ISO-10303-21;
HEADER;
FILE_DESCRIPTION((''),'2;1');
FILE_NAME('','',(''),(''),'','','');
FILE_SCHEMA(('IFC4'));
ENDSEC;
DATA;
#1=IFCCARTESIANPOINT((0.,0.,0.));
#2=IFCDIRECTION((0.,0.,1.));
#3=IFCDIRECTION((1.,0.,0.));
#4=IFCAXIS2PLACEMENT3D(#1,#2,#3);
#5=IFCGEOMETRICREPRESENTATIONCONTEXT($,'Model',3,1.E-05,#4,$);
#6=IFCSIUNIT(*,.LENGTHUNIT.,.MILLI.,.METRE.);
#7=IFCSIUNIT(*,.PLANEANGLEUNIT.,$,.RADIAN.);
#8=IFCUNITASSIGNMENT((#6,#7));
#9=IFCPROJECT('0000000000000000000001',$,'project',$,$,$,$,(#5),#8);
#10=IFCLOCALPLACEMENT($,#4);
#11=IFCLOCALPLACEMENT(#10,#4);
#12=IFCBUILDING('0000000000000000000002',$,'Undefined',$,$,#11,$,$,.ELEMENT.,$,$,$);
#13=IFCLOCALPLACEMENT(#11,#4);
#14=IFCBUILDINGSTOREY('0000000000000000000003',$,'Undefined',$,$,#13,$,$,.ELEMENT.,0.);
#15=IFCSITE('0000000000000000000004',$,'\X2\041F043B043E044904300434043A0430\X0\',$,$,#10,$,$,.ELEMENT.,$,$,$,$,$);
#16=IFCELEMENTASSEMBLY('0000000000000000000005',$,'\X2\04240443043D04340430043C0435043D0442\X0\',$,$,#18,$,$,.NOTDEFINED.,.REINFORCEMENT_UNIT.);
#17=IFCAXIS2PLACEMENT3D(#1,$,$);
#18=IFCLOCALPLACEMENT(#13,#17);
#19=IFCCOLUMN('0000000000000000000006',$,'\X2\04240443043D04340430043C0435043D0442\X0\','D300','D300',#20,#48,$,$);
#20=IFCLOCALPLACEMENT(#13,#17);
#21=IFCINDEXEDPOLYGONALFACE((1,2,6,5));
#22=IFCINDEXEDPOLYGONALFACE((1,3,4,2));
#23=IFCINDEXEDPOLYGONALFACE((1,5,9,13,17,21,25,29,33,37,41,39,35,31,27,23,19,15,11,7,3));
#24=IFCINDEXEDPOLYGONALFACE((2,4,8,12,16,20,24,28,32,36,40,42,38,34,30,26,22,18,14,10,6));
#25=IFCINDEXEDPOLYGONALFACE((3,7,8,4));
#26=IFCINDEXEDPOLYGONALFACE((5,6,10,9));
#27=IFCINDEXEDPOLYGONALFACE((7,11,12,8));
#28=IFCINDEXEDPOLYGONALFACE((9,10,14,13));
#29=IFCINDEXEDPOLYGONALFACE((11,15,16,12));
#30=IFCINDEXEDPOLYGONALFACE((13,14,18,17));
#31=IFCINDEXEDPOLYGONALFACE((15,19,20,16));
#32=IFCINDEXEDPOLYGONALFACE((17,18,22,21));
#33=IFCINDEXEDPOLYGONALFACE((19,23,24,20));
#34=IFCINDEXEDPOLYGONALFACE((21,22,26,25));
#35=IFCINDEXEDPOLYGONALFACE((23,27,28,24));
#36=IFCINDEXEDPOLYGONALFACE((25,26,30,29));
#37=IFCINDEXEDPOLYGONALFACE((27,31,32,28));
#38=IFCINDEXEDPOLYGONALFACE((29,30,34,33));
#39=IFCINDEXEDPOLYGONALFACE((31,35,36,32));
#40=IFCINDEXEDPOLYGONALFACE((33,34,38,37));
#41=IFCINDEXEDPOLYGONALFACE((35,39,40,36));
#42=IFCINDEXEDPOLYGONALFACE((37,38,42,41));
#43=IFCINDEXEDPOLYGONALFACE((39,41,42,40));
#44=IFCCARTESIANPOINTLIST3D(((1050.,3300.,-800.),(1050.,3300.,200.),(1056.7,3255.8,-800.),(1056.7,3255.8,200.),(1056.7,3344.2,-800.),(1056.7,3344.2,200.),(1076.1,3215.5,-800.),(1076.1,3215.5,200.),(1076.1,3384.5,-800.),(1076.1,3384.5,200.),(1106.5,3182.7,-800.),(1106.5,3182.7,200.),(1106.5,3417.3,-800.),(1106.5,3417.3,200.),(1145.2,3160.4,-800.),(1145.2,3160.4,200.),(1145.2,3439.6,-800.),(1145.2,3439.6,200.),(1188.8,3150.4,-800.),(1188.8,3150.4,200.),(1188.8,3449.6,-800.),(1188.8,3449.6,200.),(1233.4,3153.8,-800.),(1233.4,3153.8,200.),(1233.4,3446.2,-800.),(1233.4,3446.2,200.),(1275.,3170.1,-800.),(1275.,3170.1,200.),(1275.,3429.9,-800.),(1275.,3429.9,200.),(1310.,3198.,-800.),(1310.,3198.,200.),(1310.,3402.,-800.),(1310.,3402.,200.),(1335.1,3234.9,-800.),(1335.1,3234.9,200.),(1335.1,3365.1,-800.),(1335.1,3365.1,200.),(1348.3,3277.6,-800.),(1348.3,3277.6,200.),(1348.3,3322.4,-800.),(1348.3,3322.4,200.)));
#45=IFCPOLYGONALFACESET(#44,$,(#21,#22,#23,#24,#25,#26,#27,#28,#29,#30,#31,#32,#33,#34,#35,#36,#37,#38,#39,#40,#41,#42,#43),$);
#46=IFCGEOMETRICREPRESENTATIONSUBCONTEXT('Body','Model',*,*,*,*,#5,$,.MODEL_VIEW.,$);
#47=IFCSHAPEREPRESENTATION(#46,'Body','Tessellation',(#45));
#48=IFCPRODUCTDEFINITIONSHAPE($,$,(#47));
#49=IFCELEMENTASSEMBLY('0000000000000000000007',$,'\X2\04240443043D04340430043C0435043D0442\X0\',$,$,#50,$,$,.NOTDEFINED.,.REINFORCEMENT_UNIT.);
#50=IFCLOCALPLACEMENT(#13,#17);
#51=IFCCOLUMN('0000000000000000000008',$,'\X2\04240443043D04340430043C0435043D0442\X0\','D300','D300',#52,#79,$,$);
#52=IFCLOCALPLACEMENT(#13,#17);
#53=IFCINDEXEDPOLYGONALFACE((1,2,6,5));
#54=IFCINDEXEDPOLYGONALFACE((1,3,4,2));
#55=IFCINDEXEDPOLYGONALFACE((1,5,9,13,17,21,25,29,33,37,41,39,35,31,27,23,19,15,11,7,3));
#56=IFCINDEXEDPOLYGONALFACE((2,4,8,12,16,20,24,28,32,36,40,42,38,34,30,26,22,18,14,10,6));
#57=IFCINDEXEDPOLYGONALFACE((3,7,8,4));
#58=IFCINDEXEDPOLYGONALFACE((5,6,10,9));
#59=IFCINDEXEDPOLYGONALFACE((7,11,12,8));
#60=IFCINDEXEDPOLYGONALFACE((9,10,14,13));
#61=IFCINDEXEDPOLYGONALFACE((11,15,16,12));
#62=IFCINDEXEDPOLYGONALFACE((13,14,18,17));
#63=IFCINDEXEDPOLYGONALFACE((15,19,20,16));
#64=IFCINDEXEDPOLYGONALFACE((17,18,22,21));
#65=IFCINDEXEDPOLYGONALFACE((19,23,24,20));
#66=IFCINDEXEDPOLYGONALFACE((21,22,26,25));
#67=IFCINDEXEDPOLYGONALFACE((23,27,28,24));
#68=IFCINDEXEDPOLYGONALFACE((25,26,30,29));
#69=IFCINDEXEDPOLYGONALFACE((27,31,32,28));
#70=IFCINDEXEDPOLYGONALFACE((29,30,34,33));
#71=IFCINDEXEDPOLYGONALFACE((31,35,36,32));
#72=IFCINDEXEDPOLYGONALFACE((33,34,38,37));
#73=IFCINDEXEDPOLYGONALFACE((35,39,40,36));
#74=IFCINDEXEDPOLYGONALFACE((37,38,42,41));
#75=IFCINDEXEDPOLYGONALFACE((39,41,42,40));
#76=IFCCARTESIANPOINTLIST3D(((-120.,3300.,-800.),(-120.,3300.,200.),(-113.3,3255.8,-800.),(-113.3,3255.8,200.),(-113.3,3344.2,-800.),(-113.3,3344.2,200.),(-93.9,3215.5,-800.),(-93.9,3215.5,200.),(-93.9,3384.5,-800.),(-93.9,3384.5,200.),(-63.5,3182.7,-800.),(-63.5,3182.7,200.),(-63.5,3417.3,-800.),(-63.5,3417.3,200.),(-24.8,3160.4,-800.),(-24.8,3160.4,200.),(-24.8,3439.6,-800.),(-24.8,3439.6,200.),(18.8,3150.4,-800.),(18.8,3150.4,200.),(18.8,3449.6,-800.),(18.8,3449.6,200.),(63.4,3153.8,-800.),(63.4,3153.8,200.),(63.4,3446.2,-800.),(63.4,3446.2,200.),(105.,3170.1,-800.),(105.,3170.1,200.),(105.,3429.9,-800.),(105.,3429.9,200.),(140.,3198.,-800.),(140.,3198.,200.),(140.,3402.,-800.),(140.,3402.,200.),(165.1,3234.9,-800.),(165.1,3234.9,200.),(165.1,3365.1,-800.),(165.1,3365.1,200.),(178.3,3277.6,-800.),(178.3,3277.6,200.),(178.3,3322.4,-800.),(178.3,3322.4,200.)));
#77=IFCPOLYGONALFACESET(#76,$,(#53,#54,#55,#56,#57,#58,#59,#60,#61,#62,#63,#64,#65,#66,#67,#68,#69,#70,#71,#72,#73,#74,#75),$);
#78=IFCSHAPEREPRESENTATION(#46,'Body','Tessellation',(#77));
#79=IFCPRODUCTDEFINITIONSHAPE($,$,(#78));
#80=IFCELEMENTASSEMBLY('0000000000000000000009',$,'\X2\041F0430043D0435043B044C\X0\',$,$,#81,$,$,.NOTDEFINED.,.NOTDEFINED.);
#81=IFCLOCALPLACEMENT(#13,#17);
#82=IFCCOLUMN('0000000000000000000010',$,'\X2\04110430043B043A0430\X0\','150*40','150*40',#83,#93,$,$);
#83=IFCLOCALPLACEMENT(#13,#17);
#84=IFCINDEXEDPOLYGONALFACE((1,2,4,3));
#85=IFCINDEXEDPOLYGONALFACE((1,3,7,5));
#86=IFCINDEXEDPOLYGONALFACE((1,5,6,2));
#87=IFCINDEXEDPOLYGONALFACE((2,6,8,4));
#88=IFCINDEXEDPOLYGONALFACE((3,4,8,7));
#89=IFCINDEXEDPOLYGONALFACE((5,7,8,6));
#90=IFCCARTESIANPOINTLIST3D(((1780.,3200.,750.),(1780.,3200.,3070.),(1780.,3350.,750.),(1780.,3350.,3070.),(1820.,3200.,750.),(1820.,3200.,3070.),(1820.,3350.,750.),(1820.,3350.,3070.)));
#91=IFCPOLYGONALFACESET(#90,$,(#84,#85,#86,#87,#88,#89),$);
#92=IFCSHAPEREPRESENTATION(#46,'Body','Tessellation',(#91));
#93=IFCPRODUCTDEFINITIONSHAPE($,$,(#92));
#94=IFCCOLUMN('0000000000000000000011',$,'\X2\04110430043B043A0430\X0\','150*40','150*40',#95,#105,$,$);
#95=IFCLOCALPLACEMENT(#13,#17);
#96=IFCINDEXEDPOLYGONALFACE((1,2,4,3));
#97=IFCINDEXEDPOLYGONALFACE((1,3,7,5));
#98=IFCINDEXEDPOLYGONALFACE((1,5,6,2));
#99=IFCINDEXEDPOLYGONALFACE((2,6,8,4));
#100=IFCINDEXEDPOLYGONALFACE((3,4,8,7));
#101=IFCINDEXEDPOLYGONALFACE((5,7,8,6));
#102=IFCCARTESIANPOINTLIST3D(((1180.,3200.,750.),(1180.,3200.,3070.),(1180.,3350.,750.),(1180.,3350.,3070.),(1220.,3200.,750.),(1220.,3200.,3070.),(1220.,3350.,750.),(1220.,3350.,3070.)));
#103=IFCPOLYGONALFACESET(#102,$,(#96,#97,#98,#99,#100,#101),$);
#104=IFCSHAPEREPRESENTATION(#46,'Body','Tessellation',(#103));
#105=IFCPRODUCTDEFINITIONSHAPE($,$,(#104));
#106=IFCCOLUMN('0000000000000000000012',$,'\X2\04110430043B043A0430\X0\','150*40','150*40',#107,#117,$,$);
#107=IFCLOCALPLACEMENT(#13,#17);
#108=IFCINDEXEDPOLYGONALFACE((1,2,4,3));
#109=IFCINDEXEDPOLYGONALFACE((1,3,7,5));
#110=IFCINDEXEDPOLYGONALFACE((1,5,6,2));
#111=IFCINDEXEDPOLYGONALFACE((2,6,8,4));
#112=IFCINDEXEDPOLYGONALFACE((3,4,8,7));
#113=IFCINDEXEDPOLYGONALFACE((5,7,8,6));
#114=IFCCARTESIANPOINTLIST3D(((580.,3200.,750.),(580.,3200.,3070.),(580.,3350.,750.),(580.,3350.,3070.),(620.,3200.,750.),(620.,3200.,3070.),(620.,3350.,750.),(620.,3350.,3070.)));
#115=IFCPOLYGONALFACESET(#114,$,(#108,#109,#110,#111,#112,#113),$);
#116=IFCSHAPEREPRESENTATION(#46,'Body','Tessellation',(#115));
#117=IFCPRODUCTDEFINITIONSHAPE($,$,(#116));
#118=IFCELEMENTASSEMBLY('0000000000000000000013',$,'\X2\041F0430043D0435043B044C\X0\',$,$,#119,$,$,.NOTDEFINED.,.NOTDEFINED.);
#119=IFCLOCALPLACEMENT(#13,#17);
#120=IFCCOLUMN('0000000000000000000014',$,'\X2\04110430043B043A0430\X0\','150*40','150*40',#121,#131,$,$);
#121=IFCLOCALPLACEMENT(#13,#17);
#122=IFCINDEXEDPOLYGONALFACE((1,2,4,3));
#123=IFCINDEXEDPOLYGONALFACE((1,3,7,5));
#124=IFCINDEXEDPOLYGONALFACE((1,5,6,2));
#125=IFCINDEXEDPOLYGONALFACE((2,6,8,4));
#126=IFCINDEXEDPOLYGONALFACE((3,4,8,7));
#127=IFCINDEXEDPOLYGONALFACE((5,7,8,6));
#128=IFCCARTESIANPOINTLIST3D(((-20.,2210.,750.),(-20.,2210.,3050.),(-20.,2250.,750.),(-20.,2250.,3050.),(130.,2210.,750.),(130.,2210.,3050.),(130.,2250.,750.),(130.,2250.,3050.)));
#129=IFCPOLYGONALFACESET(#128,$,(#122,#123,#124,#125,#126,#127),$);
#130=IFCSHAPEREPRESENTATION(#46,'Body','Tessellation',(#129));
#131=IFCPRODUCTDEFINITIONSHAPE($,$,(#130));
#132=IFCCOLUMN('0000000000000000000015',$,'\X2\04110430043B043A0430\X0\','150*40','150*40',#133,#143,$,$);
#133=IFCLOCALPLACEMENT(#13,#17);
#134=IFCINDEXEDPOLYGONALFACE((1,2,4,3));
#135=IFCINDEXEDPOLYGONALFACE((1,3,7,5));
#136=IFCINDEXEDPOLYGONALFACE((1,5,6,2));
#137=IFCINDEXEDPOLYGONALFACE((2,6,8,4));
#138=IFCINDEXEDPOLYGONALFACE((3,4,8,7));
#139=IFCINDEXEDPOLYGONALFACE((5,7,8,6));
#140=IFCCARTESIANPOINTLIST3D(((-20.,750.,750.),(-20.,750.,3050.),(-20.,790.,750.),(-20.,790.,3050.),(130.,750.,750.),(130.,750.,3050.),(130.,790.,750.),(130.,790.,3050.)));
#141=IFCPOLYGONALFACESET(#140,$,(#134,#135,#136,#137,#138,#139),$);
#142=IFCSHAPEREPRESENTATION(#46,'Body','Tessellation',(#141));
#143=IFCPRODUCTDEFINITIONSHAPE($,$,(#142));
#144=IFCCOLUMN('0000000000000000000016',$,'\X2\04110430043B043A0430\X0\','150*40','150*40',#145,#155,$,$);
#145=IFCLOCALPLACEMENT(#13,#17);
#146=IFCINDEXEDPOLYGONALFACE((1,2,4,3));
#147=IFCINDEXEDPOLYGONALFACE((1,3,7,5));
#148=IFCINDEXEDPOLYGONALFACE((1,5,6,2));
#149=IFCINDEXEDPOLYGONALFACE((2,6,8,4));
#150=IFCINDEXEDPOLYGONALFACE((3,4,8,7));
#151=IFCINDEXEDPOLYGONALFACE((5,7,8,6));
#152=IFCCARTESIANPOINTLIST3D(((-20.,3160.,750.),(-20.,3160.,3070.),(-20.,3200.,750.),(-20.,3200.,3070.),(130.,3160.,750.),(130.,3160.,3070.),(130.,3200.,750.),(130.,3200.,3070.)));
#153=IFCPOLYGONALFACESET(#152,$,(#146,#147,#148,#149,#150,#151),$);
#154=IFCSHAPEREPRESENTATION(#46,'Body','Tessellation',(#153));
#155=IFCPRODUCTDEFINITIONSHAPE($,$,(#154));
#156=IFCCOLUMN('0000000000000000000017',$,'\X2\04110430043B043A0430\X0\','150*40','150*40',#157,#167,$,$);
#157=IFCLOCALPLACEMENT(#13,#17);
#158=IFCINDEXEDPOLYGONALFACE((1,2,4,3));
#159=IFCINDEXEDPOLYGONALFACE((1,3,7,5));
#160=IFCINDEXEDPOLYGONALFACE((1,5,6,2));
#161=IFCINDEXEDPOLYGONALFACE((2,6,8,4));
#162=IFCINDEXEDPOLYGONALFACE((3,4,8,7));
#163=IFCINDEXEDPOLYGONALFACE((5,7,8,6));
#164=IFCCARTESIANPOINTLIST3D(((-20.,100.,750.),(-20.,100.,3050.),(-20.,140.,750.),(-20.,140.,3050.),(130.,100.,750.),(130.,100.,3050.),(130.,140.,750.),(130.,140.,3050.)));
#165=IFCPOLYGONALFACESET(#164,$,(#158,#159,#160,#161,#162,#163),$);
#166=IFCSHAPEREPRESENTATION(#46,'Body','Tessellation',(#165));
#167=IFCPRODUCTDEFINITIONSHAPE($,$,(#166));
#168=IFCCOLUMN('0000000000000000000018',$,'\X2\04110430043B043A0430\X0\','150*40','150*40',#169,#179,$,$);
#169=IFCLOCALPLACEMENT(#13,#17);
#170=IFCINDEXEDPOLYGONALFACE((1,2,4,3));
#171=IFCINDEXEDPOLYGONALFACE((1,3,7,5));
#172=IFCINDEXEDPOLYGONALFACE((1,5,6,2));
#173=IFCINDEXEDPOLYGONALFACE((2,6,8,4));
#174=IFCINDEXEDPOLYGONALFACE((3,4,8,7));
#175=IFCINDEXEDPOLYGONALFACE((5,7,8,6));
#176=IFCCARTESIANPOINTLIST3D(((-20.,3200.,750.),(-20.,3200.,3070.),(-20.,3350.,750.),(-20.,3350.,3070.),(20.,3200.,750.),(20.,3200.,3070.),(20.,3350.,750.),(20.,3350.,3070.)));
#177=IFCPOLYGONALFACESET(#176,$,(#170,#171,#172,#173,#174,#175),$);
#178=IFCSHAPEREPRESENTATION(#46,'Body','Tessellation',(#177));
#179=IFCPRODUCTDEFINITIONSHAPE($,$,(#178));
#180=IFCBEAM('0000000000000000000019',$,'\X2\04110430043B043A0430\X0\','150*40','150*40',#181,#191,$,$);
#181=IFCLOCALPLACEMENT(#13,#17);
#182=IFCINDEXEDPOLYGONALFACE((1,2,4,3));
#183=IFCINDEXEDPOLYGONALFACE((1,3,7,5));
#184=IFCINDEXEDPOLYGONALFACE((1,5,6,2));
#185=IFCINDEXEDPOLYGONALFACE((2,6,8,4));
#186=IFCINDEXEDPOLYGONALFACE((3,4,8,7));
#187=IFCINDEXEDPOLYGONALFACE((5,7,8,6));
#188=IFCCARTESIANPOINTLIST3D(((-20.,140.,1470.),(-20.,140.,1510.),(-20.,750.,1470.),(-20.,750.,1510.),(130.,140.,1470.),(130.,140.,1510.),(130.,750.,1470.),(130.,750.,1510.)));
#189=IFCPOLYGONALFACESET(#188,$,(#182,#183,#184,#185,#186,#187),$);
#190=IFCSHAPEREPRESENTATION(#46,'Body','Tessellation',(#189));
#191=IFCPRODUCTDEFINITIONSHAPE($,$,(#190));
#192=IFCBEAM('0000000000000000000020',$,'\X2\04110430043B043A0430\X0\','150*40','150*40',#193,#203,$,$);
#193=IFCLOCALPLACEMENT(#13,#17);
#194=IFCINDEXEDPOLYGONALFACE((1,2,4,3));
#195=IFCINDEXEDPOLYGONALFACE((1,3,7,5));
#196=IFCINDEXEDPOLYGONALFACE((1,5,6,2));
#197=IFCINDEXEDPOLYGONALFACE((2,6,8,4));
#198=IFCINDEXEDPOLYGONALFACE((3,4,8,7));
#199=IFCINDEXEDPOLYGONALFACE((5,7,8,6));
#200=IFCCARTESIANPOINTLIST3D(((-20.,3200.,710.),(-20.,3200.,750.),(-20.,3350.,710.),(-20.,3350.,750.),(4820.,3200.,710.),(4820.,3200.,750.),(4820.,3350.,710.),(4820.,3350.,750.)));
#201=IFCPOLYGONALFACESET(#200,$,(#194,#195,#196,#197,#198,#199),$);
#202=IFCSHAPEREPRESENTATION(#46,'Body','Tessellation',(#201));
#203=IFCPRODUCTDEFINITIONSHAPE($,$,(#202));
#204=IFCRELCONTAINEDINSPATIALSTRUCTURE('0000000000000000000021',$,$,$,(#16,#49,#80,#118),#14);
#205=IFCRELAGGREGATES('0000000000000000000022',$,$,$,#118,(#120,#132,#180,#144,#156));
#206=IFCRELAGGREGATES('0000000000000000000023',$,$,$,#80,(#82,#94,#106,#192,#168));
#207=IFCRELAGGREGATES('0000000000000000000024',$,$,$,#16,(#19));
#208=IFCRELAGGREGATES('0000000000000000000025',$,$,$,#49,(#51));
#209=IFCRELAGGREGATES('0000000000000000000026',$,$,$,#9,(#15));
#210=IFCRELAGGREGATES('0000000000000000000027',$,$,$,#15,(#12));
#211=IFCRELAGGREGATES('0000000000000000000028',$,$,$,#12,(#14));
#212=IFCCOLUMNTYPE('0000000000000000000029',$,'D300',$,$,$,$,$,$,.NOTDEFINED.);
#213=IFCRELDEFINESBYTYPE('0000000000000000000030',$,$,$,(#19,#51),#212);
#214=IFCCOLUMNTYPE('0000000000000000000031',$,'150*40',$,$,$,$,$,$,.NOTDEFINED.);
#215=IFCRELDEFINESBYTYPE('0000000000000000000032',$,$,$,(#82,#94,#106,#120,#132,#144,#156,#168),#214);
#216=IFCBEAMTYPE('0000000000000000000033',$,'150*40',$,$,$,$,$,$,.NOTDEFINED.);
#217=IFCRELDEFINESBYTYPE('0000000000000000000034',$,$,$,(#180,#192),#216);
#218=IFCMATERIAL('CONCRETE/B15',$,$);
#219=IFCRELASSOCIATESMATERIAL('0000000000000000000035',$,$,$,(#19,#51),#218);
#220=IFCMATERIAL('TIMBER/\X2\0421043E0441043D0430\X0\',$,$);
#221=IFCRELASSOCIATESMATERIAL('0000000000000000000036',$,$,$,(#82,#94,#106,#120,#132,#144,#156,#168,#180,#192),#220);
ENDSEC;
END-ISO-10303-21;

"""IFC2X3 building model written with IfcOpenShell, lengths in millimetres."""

from ifc_helpers import new_model, si_unit, frame, origin_with_axes, origin_2d_with_axis, place, context, subcontext, project, spatial, rectangle, circle, extrude, material, type_object, element, aggregate, save


model = new_model("IFC2X3")

# Units and contexts
model_context = context("Model", 3, precision=1e-05, world=origin_with_axes())
body_context = subcontext(model_context, "Body", "Model", "MODEL_VIEW")
ifc_project = project(units=[si_unit("LENGTHUNIT", "METRE", prefix="MILLI"), si_unit("PLANEANGLEUNIT", "RADIAN")], contexts=[model_context])

# Site, building, storey
site_placement = place(None, origin_with_axes())
site = spatial("IfcSite", under=ifc_project, at=site_placement, Name="Площадка", CompositionType="ELEMENT")
building_placement = place(site_placement, origin_with_axes())
building = spatial("IfcBuilding", under=site, at=building_placement, Name="Undefined", CompositionType="ELEMENT")
storey_placement = place(building_placement, origin_with_axes())
storey = spatial("IfcBuildingStorey", under=building, at=storey_placement, Name="Undefined", CompositionType="ELEMENT", Elevation=0.0)

# Element assemblies, columns
assembly_1_placement = place(storey_placement, origin_with_axes())
assembly_1 = element("IfcElementAssembly", 1, at=assembly_1_placement, inside=storey, Name="Фундамент", AssemblyPlace="NOTDEFINED", PredefinedType="REINFORCEMENT_UNIT")
ifc_material_1 = material(Name="CONCRETE/B15")
column_type_1 = type_object("IfcColumnType", Name="D300", PredefinedType="NOTDEFINED")
column_1_placement = place(assembly_1_placement, frame((1200.0, 3300.0, -800.0), z_axis=(0.0, 0.0, 1.0), x_axis=(0.0, 1.0, 0.0)))
column_1 = element("IfcColumn", 2, at=column_1_placement, type_object=column_type_1, material=ifc_material_1, Name="Фундамент", Description="D300", ObjectType="D300", context=body_context, shape_type="SweptSolid", body=[
    extrude(circle(Radius=150.0, at=origin_2d_with_axis()), frame((0.0, 0.0, 1000.0), z_axis=(0.0, 0.0, -1.0), x_axis=(0.0, 1.0, 0.0)), (0.0, 0.0, 1.0), 1000.0),
])
assembly_2_placement = place(storey_placement, origin_with_axes())
assembly_2 = element("IfcElementAssembly", 3, at=assembly_2_placement, inside=storey, Name="Фундамент", AssemblyPlace="NOTDEFINED", PredefinedType="REINFORCEMENT_UNIT")
column_2_placement = place(assembly_2_placement, frame((30.0, 3300.0, -800.0), z_axis=(0.0, 0.0, 1.0), x_axis=(0.0, 1.0, 0.0)))
column_2 = element("IfcColumn", 4, at=column_2_placement, type_object=column_type_1, material=ifc_material_1, Name="Фундамент", Description="D300", ObjectType="D300", context=body_context, shape_type="SweptSolid", body=[
    extrude(circle(Radius=150.0, at=origin_2d_with_axis()), frame((0.0, 0.0, 1000.0), z_axis=(0.0, 0.0, -1.0), x_axis=(0.0, 1.0, 0.0)), (0.0, 0.0, 1.0), 1000.0),
])

# Element assemblies, columns
assembly_3_placement = place(storey_placement, origin_with_axes())
assembly_3 = element("IfcElementAssembly", 5, at=assembly_3_placement, inside=storey, Name="Панель", AssemblyPlace="NOTDEFINED", PredefinedType="NOTDEFINED")
ifc_material_2 = material(Name="TIMBER/Сосна")
column_type_2 = type_object("IfcColumnType", Name="150*40", PredefinedType="NOTDEFINED")
column_3_placement = place(assembly_3_placement, frame((1800.0, 3275.0, 750.0), z_axis=(0.0, 0.0, 1.0), x_axis=(0.0, 1.0, 0.0)))
column_3 = element("IfcColumn", 6, at=column_3_placement, type_object=column_type_2, material=ifc_material_2, Name="Балка", Description="150*40", ObjectType="150*40", context=body_context, shape_type="SweptSolid", body=[
    extrude(rectangle(XDim=40.0, YDim=150.0, at=origin_2d_with_axis()), frame((0.0, 0.0, 2320.0), z_axis=(0.0, 0.0, -1.0), x_axis=(0.0, 1.0, 0.0)), (0.0, 0.0, 1.0), 2320.0),
])
column_4_placement = place(assembly_3_placement, frame((1200.0, 3275.0, 750.0), z_axis=(0.0, 0.0, 1.0), x_axis=(0.0, 1.0, 0.0)))
column_4 = element("IfcColumn", 7, at=column_4_placement, type_object=column_type_2, material=ifc_material_2, Name="Балка", Description="150*40", ObjectType="150*40", context=body_context, shape_type="SweptSolid", body=[
    extrude(rectangle(XDim=40.0, YDim=150.0, at=origin_2d_with_axis()), frame((0.0, 0.0, 2320.0), z_axis=(0.0, 0.0, -1.0), x_axis=(0.0, 1.0, 0.0)), (0.0, 0.0, 1.0), 2320.0),
])
column_5_placement = place(assembly_3_placement, frame((600.0, 3275.0, 750.0), z_axis=(0.0, 0.0, 1.0), x_axis=(0.0, 1.0, 0.0)))
column_5 = element("IfcColumn", 8, at=column_5_placement, type_object=column_type_2, material=ifc_material_2, Name="Балка", Description="150*40", ObjectType="150*40", context=body_context, shape_type="SweptSolid", body=[
    extrude(rectangle(XDim=40.0, YDim=150.0, at=origin_2d_with_axis()), frame((0.0, 0.0, 2320.0), z_axis=(0.0, 0.0, -1.0), x_axis=(0.0, 1.0, 0.0)), (0.0, 0.0, 1.0), 2320.0),
])
assembly_4_placement = place(storey_placement, origin_with_axes())
assembly_4 = element("IfcElementAssembly", 9, at=assembly_4_placement, inside=storey, Name="Панель", AssemblyPlace="NOTDEFINED", PredefinedType="NOTDEFINED")
column_6_placement = place(assembly_4_placement, frame((55.0, 2230.0, 750.0), z_axis=(0.0, 0.0, 1.0), x_axis=(-1.0, 0.0, 0.0)))
column_6 = element("IfcColumn", 10, at=column_6_placement, type_object=column_type_2, material=ifc_material_2, Name="Балка", Description="150*40", ObjectType="150*40", context=body_context, shape_type="SweptSolid", body=[
    extrude(rectangle(XDim=40.0, YDim=150.0, at=origin_2d_with_axis()), frame((0.0, 0.0, 2300.0), z_axis=(0.0, 0.0, -1.0), x_axis=(0.0, 1.0, 0.0)), (0.0, 0.0, 1.0), 2300.0),
])
column_7_placement = place(assembly_4_placement, frame((55.0, 770.0, 750.0), z_axis=(0.0, 0.0, 1.0), x_axis=(-1.0, 0.0, 0.0)))
column_7 = element("IfcColumn", 11, at=column_7_placement, type_object=column_type_2, material=ifc_material_2, Name="Балка", Description="150*40", ObjectType="150*40", context=body_context, shape_type="SweptSolid", body=[
    extrude(rectangle(XDim=40.0, YDim=150.0, at=origin_2d_with_axis()), frame((0.0, 0.0, 2300.0), z_axis=(0.0, 0.0, -1.0), x_axis=(0.0, 1.0, 0.0)), (0.0, 0.0, 1.0), 2300.0),
])
column_8_placement = place(assembly_4_placement, frame((55.0, 3180.0, 750.0), z_axis=(0.0, 0.0, 1.0), x_axis=(-1.0, 0.0, 0.0)))
column_8 = element("IfcColumn", 12, at=column_8_placement, type_object=column_type_2, material=ifc_material_2, Name="Балка", Description="150*40", ObjectType="150*40", context=body_context, shape_type="SweptSolid", body=[
    extrude(rectangle(XDim=40.0, YDim=150.0, at=origin_2d_with_axis()), frame((0.0, 0.0, 2320.0), z_axis=(0.0, 0.0, -1.0), x_axis=(0.0, 1.0, 0.0)), (0.0, 0.0, 1.0), 2320.0),
])
column_9_placement = place(assembly_4_placement, frame((55.0, 120.0, 750.0), z_axis=(0.0, 0.0, 1.0), x_axis=(-1.0, 0.0, 0.0)))
column_9 = element("IfcColumn", 13, at=column_9_placement, type_object=column_type_2, material=ifc_material_2, Name="Балка", Description="150*40", ObjectType="150*40", context=body_context, shape_type="SweptSolid", body=[
    extrude(rectangle(XDim=40.0, YDim=150.0, at=origin_2d_with_axis()), frame((0.0, 0.0, 2300.0), z_axis=(0.0, 0.0, -1.0), x_axis=(0.0, 1.0, 0.0)), (0.0, 0.0, 1.0), 2300.0),
])

# Column
column_10_placement = place(assembly_3_placement, frame((0.0, 3275.0, 750.0), z_axis=(0.0, 0.0, 1.0), x_axis=(0.0, 1.0, 0.0)))
column_10 = element("IfcColumn", 14, at=column_10_placement, type_object=column_type_2, material=ifc_material_2, Name="Балка", Description="150*40", ObjectType="150*40", context=body_context, shape_type="SweptSolid", body=[
    extrude(rectangle(XDim=40.0, YDim=150.0, at=origin_2d_with_axis()), frame((0.0, 0.0, 2320.0), z_axis=(0.0, 0.0, -1.0), x_axis=(0.0, 1.0, 0.0)), (0.0, 0.0, 1.0), 2320.0),
])

# Beams
beam_type_1 = type_object("IfcBeamType", Name="150*40", PredefinedType="NOTDEFINED")
beam_1_placement = place(assembly_4_placement, frame((55.0, 140.0, 1490.0), z_axis=(-1.0, 0.0, 0.0), x_axis=(0.0, 1.0, 0.0)))
beam_1 = element("IfcBeam", 15, at=beam_1_placement, type_object=beam_type_1, material=ifc_material_2, Name="Балка", Description="150*40", ObjectType="150*40", context=body_context, shape_type="SweptSolid", body=[
    extrude(rectangle(XDim=40.0, YDim=150.0, at=origin_2d_with_axis()), frame((610.0, 0.0, 0.0), z_axis=(-1.0, 0.0, 0.0), x_axis=(0.0, -1.0, 0.0)), (0.0, 0.0, 1.0), 610.0),
])
aggregate(assembly_4, [column_6, column_7, beam_1, column_8, column_9])
beam_2_placement = place(assembly_3_placement, frame((-20.0, 3275.0, 730.0), z_axis=(0.0, 1.0, 0.0), x_axis=(1.0, 0.0, 0.0)))
beam_2 = element("IfcBeam", 16, at=beam_2_placement, type_object=beam_type_1, material=ifc_material_2, Name="Балка", Description="150*40", ObjectType="150*40", context=body_context, shape_type="SweptSolid", body=[
    extrude(rectangle(XDim=40.0, YDim=150.0, at=origin_2d_with_axis()), frame((4840.0, 0.0, 0.0), z_axis=(-1.0, 0.0, 0.0), x_axis=(0.0, -1.0, 0.0)), (0.0, 0.0, 1.0), 4840.0),
])
aggregate(assembly_3, [column_3, column_4, column_5, beam_2, column_10])

aggregate(assembly_1, [column_1])
aggregate(assembly_2, [column_2])

save(model, "model.ifc")
